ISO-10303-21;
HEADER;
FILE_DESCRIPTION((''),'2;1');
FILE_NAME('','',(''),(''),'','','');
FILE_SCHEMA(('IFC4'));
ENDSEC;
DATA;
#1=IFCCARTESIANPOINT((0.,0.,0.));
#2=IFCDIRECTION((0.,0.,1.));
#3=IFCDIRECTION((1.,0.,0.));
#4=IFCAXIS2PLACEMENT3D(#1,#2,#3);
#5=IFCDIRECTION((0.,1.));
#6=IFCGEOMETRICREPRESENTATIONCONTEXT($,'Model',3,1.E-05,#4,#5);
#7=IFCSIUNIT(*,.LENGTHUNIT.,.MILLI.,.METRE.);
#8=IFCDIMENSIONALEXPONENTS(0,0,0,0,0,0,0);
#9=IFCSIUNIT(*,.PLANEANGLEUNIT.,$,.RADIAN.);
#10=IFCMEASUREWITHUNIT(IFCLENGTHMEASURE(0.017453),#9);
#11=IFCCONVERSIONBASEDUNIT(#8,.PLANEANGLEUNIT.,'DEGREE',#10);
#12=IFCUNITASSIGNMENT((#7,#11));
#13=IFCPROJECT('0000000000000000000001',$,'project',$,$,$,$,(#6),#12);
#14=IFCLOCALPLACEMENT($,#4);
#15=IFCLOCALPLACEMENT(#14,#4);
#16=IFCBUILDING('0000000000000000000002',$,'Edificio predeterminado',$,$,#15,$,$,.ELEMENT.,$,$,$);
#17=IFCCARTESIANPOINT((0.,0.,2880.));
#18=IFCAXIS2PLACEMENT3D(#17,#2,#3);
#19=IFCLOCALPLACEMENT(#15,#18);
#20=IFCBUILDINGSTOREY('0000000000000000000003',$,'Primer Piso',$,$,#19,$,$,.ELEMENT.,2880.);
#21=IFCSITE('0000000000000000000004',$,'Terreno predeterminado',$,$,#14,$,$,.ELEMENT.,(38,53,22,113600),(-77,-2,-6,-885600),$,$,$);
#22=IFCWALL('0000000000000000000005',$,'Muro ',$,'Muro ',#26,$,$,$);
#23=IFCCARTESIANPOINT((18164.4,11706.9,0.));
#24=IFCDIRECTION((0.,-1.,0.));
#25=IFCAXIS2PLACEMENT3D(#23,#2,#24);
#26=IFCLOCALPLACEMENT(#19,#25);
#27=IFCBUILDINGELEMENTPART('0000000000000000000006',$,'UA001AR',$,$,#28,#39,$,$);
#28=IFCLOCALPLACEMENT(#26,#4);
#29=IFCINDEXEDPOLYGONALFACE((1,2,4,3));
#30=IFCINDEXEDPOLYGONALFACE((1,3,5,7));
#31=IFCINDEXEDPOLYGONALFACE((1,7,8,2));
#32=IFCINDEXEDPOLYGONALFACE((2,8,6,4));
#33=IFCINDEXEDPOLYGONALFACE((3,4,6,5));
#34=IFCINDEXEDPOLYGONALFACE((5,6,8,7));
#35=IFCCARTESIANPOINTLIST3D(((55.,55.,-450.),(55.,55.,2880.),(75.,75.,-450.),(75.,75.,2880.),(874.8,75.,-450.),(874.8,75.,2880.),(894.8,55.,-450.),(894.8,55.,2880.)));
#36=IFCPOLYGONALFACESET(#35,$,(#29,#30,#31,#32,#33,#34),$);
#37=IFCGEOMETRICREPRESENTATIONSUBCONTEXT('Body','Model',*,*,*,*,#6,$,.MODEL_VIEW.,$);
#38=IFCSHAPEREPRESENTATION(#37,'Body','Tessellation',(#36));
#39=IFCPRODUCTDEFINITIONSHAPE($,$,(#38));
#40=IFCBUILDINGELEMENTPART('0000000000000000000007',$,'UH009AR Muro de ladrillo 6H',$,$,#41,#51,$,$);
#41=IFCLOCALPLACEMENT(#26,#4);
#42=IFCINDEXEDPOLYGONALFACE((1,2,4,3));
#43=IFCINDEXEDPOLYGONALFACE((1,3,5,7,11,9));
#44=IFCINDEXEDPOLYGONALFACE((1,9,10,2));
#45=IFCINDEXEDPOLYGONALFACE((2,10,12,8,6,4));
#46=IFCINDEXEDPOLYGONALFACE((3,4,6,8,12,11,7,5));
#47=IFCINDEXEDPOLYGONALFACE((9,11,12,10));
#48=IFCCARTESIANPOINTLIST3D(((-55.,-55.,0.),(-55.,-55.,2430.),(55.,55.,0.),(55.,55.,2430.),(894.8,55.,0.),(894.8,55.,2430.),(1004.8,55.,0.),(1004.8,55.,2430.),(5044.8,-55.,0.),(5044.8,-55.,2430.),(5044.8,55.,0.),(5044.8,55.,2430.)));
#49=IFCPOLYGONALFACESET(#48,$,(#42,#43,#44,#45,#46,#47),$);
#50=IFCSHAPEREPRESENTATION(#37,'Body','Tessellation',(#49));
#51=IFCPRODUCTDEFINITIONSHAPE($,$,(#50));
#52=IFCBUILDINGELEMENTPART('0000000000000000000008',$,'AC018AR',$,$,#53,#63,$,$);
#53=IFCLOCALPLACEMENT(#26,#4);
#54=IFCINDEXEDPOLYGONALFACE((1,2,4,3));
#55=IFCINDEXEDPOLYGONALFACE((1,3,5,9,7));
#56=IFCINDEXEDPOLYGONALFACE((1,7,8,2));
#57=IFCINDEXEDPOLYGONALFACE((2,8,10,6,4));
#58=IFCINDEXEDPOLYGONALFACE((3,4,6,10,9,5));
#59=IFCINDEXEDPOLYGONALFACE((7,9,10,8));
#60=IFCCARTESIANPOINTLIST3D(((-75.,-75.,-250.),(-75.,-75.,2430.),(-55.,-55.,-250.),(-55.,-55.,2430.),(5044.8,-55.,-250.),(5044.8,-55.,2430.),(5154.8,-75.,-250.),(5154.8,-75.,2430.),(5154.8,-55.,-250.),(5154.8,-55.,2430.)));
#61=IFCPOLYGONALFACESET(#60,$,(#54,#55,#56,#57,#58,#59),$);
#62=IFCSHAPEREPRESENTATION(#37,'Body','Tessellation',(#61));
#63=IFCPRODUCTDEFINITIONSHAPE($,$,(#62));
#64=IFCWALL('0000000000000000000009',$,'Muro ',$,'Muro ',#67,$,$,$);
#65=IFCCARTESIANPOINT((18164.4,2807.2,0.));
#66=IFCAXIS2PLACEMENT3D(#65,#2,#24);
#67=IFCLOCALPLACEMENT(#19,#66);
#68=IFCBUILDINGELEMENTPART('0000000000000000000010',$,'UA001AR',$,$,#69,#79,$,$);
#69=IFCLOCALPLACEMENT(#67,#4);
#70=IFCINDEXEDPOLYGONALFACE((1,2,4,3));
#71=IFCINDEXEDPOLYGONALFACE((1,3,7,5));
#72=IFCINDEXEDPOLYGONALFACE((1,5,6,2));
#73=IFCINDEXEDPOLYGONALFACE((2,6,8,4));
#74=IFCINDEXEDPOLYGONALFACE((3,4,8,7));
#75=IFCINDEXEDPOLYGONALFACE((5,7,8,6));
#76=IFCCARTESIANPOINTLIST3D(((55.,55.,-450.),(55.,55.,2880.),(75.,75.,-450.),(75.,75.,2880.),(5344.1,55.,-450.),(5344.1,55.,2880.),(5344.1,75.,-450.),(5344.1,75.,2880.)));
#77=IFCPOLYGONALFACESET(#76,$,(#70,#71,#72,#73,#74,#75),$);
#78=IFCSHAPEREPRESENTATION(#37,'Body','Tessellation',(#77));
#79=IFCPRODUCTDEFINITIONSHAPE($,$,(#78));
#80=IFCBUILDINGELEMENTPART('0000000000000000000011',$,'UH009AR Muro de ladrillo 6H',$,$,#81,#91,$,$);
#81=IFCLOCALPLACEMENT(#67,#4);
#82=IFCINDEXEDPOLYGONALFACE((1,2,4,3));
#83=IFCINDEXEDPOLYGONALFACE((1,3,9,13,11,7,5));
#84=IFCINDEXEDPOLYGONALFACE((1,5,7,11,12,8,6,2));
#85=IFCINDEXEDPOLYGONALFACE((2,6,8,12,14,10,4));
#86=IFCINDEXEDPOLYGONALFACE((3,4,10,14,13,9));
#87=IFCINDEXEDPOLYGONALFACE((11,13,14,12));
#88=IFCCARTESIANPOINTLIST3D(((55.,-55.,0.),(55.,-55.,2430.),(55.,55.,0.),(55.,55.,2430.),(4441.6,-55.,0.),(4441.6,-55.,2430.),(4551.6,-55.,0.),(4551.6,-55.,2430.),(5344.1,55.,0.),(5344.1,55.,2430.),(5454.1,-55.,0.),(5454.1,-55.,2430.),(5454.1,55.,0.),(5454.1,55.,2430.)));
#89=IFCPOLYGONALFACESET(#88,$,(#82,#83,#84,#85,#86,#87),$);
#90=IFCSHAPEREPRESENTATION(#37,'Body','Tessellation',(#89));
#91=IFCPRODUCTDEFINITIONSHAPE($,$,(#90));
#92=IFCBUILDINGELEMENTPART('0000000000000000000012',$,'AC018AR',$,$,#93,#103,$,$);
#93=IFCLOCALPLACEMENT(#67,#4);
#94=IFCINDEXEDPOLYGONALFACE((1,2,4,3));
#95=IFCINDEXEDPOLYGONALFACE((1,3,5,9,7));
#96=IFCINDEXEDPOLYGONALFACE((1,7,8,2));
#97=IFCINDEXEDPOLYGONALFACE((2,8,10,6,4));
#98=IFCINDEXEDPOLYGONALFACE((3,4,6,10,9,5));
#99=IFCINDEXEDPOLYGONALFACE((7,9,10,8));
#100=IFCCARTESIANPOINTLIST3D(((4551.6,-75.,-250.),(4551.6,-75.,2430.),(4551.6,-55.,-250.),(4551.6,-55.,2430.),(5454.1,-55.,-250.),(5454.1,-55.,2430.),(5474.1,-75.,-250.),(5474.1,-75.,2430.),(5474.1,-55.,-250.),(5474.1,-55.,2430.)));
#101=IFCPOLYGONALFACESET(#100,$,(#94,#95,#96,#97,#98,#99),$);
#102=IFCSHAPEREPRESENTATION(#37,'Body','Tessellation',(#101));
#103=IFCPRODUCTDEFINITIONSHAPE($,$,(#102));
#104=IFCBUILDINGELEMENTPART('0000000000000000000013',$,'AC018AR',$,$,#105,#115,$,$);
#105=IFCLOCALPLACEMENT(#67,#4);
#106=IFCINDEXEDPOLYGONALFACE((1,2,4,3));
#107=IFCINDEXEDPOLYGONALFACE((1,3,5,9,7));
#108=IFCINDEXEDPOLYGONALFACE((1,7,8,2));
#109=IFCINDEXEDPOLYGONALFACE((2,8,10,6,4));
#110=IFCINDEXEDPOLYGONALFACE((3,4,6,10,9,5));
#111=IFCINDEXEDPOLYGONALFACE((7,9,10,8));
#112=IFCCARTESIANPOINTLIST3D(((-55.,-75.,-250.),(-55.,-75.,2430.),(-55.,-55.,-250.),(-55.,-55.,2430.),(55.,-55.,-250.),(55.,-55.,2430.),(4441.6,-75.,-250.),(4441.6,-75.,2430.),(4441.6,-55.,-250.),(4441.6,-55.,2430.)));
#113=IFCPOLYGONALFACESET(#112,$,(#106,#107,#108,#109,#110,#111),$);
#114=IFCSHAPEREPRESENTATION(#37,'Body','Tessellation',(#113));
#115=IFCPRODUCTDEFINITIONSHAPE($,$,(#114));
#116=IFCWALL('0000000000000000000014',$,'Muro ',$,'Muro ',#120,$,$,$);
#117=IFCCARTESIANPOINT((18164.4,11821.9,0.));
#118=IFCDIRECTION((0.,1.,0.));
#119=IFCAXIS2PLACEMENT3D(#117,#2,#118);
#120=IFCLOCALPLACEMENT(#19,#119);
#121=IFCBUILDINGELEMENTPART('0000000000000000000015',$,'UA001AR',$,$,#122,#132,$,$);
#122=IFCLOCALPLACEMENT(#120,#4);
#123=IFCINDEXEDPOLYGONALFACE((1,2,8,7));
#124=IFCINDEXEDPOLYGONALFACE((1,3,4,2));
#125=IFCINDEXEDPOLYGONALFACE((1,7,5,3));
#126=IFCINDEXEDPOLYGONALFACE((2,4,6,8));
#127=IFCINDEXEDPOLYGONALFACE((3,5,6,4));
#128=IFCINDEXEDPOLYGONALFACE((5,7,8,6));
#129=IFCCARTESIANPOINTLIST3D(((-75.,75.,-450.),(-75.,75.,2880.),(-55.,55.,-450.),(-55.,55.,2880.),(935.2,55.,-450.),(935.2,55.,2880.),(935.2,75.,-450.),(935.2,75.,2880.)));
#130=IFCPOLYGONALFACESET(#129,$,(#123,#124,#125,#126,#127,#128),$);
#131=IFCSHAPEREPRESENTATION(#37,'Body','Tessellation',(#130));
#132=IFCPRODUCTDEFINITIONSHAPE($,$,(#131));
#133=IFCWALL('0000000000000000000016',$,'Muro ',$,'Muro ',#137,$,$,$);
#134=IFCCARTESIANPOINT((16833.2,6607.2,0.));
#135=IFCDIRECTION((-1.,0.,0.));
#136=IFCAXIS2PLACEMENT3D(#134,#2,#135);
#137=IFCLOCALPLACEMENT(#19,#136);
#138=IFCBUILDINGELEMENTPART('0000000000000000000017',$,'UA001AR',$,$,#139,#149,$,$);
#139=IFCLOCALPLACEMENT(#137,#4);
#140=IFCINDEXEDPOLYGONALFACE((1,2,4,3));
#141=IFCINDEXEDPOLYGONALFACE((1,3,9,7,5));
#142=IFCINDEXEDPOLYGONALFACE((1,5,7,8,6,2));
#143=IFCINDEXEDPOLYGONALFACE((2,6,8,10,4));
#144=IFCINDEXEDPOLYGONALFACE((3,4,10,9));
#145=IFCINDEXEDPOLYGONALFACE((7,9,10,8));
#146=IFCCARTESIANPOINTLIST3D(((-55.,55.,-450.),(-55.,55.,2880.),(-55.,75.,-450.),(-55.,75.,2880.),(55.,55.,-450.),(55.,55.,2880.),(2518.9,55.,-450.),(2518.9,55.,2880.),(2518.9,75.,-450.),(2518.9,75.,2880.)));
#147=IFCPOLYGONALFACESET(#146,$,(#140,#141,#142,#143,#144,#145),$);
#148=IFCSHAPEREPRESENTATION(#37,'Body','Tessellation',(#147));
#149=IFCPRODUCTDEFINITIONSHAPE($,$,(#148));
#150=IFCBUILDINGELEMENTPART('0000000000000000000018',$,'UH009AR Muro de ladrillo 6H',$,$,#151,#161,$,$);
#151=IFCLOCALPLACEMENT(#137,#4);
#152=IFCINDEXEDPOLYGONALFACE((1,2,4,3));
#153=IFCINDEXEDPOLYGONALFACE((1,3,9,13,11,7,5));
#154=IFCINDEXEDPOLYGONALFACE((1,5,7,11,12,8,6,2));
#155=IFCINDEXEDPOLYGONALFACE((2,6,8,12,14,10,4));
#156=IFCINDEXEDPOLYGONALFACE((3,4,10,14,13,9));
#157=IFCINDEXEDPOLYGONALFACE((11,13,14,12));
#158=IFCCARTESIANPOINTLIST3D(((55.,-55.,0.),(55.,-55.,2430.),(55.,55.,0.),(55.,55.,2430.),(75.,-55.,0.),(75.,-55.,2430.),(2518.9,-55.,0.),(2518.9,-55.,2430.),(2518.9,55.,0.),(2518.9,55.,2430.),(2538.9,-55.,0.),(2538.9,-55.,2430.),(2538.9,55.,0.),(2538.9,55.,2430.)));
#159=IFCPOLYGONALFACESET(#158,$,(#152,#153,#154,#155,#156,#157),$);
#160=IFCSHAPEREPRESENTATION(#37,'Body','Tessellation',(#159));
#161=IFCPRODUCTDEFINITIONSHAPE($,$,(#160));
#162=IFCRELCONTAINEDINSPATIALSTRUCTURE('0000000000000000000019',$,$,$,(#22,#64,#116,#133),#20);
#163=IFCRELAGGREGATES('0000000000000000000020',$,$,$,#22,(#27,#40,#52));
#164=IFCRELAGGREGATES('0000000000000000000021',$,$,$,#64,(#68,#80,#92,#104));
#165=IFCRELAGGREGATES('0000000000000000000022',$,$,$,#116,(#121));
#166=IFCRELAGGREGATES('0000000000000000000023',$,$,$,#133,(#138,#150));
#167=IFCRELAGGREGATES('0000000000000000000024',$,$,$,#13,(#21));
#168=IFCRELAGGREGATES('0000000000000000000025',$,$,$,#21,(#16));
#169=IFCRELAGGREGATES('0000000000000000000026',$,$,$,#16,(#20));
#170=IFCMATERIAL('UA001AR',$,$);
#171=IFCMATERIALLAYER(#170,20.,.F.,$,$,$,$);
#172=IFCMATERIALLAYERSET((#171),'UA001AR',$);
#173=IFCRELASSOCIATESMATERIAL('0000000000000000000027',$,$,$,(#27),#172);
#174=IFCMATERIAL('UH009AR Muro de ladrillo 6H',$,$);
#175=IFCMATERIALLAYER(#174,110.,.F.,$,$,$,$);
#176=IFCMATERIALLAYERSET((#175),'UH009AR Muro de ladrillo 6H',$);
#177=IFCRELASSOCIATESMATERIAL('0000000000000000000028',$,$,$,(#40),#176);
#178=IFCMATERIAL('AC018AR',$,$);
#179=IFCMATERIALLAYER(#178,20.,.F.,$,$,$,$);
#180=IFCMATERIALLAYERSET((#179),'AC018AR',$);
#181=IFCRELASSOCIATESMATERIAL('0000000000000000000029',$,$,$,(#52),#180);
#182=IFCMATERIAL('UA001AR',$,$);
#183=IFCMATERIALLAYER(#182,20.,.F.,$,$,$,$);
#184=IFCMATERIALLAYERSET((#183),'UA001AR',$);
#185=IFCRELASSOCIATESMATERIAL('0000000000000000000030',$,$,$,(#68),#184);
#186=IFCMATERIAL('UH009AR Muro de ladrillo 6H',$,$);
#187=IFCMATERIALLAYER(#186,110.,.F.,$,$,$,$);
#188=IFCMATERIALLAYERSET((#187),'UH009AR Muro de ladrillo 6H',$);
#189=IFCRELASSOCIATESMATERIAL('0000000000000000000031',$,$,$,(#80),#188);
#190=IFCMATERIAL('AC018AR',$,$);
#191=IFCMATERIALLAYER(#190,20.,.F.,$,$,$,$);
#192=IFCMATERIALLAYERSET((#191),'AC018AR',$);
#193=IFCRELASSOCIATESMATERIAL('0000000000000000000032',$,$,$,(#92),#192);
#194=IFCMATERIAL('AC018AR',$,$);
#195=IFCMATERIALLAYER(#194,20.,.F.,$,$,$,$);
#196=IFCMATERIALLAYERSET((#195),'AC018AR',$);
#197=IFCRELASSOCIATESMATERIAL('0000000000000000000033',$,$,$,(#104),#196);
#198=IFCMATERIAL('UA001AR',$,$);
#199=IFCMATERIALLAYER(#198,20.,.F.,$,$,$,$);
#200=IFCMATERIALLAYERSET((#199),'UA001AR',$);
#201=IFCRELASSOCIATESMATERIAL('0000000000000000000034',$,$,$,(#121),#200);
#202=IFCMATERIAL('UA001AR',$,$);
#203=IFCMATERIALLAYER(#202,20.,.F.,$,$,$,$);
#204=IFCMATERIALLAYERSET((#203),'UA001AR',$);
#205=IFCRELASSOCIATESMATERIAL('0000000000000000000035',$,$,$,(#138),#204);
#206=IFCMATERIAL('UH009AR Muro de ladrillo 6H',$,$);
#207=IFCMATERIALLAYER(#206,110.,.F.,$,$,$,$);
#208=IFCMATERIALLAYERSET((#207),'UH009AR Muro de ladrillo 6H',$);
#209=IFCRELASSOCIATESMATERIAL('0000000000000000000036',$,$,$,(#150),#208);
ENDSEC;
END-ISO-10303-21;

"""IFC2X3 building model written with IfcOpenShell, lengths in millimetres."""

from ifc_helpers import new_model, entity, si_unit, converted_unit, direction, frame, origin_with_axes, place, context, subcontext, project, spatial, polyline, outline, extrude, material, layer, layer_set, layer_usage, element, aggregate, save


model = new_model("IFC2X3")

# Units and contexts
model_context = context("Model", 3, precision=1e-05, world=origin_with_axes(), true_north=direction((0.0, 1.0)))
body_context = subcontext(model_context, "Body", "Model", "MODEL_VIEW")
ifc_project = project(units=[si_unit("LENGTHUNIT", "METRE", prefix="MILLI"), converted_unit("PLANEANGLEUNIT", "DEGREE", entity("IfcLengthMeasure", 0.017453), si_unit("PLANEANGLEUNIT", "RADIAN"), dimensions=[0, 0, 0, 0, 0, 0, 0])], contexts=[model_context])

# Site, building, storey
site_placement = place(None, origin_with_axes())
site = spatial("IfcSite", under=ifc_project, at=site_placement, Name="Terreno predeterminado", CompositionType="ELEMENT", RefLatitude=(38, 53, 22, 113600), RefLongitude=(-77, -2, -6, -885600))
building_placement = place(site_placement, origin_with_axes())
building = spatial("IfcBuilding", under=site, at=building_placement, Name="Edificio predeterminado", CompositionType="ELEMENT")
storey_placement = place(building_placement, frame((0.0, 0.0, 2880.0), z_axis=(0.0, 0.0, 1.0), x_axis=(1.0, 0.0, 0.0)))
storey = spatial("IfcBuildingStorey", under=building, at=storey_placement, Name="Primer Piso", CompositionType="ELEMENT", Elevation=2880.0)

# Walls, building element parts
wall_1_placement = place(storey_placement, frame((18164.4, 11706.9, 0.0), z_axis=(0.0, 0.0, 1.0), x_axis=(0.0, -1.0, 0.0)))
wall_1 = element("IfcWall", 1, at=wall_1_placement, inside=storey, Name="Muro ", ObjectType="Muro ")
ifc_material_1 = material(Name="UA001AR")
ifc_layer_1 = layer(ifc_material_1, 20.0, ventilated=False)
ifc_layer_set_1 = layer_set([ifc_layer_1], Name="UA001AR")
ifc_layer_usage_1 = layer_usage(ifc_layer_set_1, "AXIS2", "NEGATIVE", -75.0)
building_element_part_1_placement = place(wall_1_placement, origin_with_axes())
building_element_part_1 = element("IfcBuildingElementPart", 2, at=building_element_part_1_placement, material=ifc_layer_usage_1, Name="UA001AR", context=body_context, shape_type="SweptSolid", body=[
    extrude(outline(polyline([(874.8, 75.0), (894.8, 55.0), (55.0, 55.0), (75.0, 75.0), (874.8, 75.0)])), frame((0.0, 0.0, -450.0), z_axis=(0.0, 0.0, 1.0), x_axis=(1.0, 0.0, 0.0)), (0.0, 0.0, 1.0), 3330.0),
])
ifc_material_2 = material(Name="UH009AR Muro de ladrillo 6H")
ifc_layer_2 = layer(ifc_material_2, 110.0, ventilated=False)
ifc_layer_set_2 = layer_set([ifc_layer_2], Name="UH009AR Muro de ladrillo 6H")
ifc_layer_usage_2 = layer_usage(ifc_layer_set_2, "AXIS2", "NEGATIVE", -55.0)
building_element_part_2_placement = place(wall_1_placement, origin_with_axes())
building_element_part_2 = element("IfcBuildingElementPart", 3, at=building_element_part_2_placement, material=ifc_layer_usage_2, Name="UH009AR Muro de ladrillo 6H", context=body_context, shape_type="SweptSolid", body=[
    extrude(outline(polyline([(5044.8, 55.0), (5044.8, -55.0), (-55.0, -55.0), (55.0, 55.0), (894.8, 55.0), (1004.8, 55.0), (5044.8, 55.0)])), origin_with_axes(), (0.0, 0.0, 1.0), 2430.0),
])
ifc_material_3 = material(Name="AC018AR")
ifc_layer_3 = layer(ifc_material_3, 20.0, ventilated=False)
ifc_layer_set_3 = layer_set([ifc_layer_3], Name="AC018AR")
ifc_layer_usage_3 = layer_usage(ifc_layer_set_3, "AXIS2", "NEGATIVE", 55.0)
building_element_part_3_placement = place(wall_1_placement, origin_with_axes())
building_element_part_3 = element("IfcBuildingElementPart", 4, at=building_element_part_3_placement, material=ifc_layer_usage_3, Name="AC018AR", context=body_context, shape_type="SweptSolid", body=[
    extrude(outline(polyline([(5154.8, -55.0), (5154.8, -75.0), (-75.0, -75.0), (-55.0, -55.0), (5044.8, -55.0), (5154.8, -55.0)])), frame((0.0, 0.0, -250.0), z_axis=(0.0, 0.0, 1.0), x_axis=(1.0, 0.0, 0.0)), (0.0, 0.0, 1.0), 2680.0),
])
aggregate(wall_1, [building_element_part_1, building_element_part_2, building_element_part_3])
wall_2_placement = place(storey_placement, frame((18164.4, 2807.2, 0.0), z_axis=(0.0, 0.0, 1.0), x_axis=(0.0, -1.0, 0.0)))
wall_2 = element("IfcWall", 5, at=wall_2_placement, inside=storey, Name="Muro ", ObjectType="Muro ")
ifc_material_4 = material(Name="UA001AR")
ifc_layer_4 = layer(ifc_material_4, 20.0, ventilated=False)
ifc_layer_set_4 = layer_set([ifc_layer_4], Name="UA001AR")
ifc_layer_usage_4 = layer_usage(ifc_layer_set_4, "AXIS2", "NEGATIVE", -75.0)
building_element_part_4_placement = place(wall_2_placement, origin_with_axes())
building_element_part_4 = element("IfcBuildingElementPart", 6, at=building_element_part_4_placement, material=ifc_layer_usage_4, Name="UA001AR", context=body_context, shape_type="SweptSolid", body=[
    extrude(outline(polyline([(5344.1, 75.0), (5344.1, 55.0), (55.0, 55.0), (75.0, 75.0), (5344.1, 75.0)])), frame((0.0, 0.0, -450.0), z_axis=(0.0, 0.0, 1.0), x_axis=(1.0, 0.0, 0.0)), (0.0, 0.0, 1.0), 3330.0),
])
ifc_material_5 = material(Name="UH009AR Muro de ladrillo 6H")
ifc_layer_5 = layer(ifc_material_5, 110.0, ventilated=False)
ifc_layer_set_5 = layer_set([ifc_layer_5], Name="UH009AR Muro de ladrillo 6H")
ifc_layer_usage_5 = layer_usage(ifc_layer_set_5, "AXIS2", "NEGATIVE", -55.0)
building_element_part_5_placement = place(wall_2_placement, origin_with_axes())
building_element_part_5 = element("IfcBuildingElementPart", 7, at=building_element_part_5_placement, material=ifc_layer_usage_5, Name="UH009AR Muro de ladrillo 6H", context=body_context, shape_type="SweptSolid", body=[
    extrude(outline(polyline([(5454.1, 55.0), (5454.1, -55.0), (4551.6, -55.0), (4441.6, -55.0), (55.0, -55.0), (55.0, 55.0), (5344.1, 55.0), (5454.1, 55.0)])), origin_with_axes(), (0.0, 0.0, 1.0), 2430.0),
])
ifc_material_6 = material(Name="AC018AR")
ifc_layer_6 = layer(ifc_material_6, 20.0, ventilated=False)
ifc_layer_set_6 = layer_set([ifc_layer_6], Name="AC018AR")
ifc_layer_usage_6 = layer_usage(ifc_layer_set_6, "AXIS2", "NEGATIVE", 55.0)
building_element_part_6_placement = place(wall_2_placement, origin_with_axes())
building_element_part_6 = element("IfcBuildingElementPart", 8, at=building_element_part_6_placement, material=ifc_layer_usage_6, Name="AC018AR", context=body_context, shape_type="SweptSolid", body=[
    extrude(outline(polyline([(5474.1, -55.0), (5474.1, -75.0), (4551.6, -75.0), (4551.6, -55.0), (5454.1, -55.0), (5474.1, -55.0)])), frame((0.0, 0.0, -250.0), z_axis=(0.0, 0.0, 1.0), x_axis=(1.0, 0.0, 0.0)), (0.0, 0.0, 1.0), 2680.0),
])
ifc_material_7 = material(Name="AC018AR")
ifc_layer_7 = layer(ifc_material_7, 20.0, ventilated=False)
ifc_layer_set_7 = layer_set([ifc_layer_7], Name="AC018AR")
ifc_layer_usage_7 = layer_usage(ifc_layer_set_7, "AXIS2", "NEGATIVE", 55.0)
building_element_part_7_placement = place(wall_2_placement, origin_with_axes())
building_element_part_7 = element("IfcBuildingElementPart", 9, at=building_element_part_7_placement, material=ifc_layer_usage_7, Name="AC018AR", context=body_context, shape_type="SweptSolid", body=[
    extrude(outline(polyline([(4441.6, -55.0), (4441.6, -75.0), (-55.0, -75.0), (-55.0, -55.0), (55.0, -55.0), (4441.6, -55.0)])), frame((0.0, 0.0, -250.0), z_axis=(0.0, 0.0, 1.0), x_axis=(1.0, 0.0, 0.0)), (0.0, 0.0, 1.0), 2680.0),
])
aggregate(wall_2, [building_element_part_4, building_element_part_5, building_element_part_6, building_element_part_7])

# Wall, building element part
wall_3_placement = place(storey_placement, frame((18164.4, 11821.9, 0.0), z_axis=(0.0, 0.0, 1.0), x_axis=(0.0, 1.0, 0.0)))
wall_3 = element("IfcWall", 10, at=wall_3_placement, inside=storey, Name="Muro ", ObjectType="Muro ")
ifc_material_8 = material(Name="UA001AR")
ifc_layer_8 = layer(ifc_material_8, 20.0, ventilated=False)
ifc_layer_set_8 = layer_set([ifc_layer_8], Name="UA001AR")
ifc_layer_usage_8 = layer_usage(ifc_layer_set_8, "AXIS2", "NEGATIVE", -75.0)
building_element_part_8_placement = place(wall_3_placement, origin_with_axes())
building_element_part_8 = element("IfcBuildingElementPart", 11, at=building_element_part_8_placement, material=ifc_layer_usage_8, Name="UA001AR", context=body_context, shape_type="SweptSolid", body=[
    extrude(outline(polyline([(935.2, 75.0), (935.2, 55.0), (-55.0, 55.0), (-75.0, 75.0), (935.2, 75.0)])), frame((0.0, 0.0, -450.0), z_axis=(0.0, 0.0, 1.0), x_axis=(1.0, 0.0, 0.0)), (0.0, 0.0, 1.0), 3330.0),
])
aggregate(wall_3, [building_element_part_8])

# Wall, building element parts
wall_4_placement = place(storey_placement, frame((16833.2, 6607.2, 0.0), z_axis=(0.0, 0.0, 1.0), x_axis=(-1.0, 0.0, 0.0)))
wall_4 = element("IfcWall", 12, at=wall_4_placement, inside=storey, Name="Muro ", ObjectType="Muro ")
ifc_material_9 = material(Name="UA001AR")
ifc_layer_9 = layer(ifc_material_9, 20.0, ventilated=False)
ifc_layer_set_9 = layer_set([ifc_layer_9], Name="UA001AR")
ifc_layer_usage_9 = layer_usage(ifc_layer_set_9, "AXIS2", "NEGATIVE", -75.0)
building_element_part_9_placement = place(wall_4_placement, origin_with_axes())
building_element_part_9 = element("IfcBuildingElementPart", 13, at=building_element_part_9_placement, material=ifc_layer_usage_9, Name="UA001AR", context=body_context, shape_type="SweptSolid", body=[
    extrude(outline(polyline([(2518.9, 75.0), (2518.9, 55.0), (55.0, 55.0), (-55.0, 55.0), (-55.0, 75.0), (2518.9, 75.0)])), frame((0.0, 0.0, -450.0), z_axis=(0.0, 0.0, 1.0), x_axis=(1.0, 0.0, 0.0)), (0.0, 0.0, 1.0), 3330.0),
])
ifc_material_10 = material(Name="UH009AR Muro de ladrillo 6H")
ifc_layer_10 = layer(ifc_material_10, 110.0, ventilated=False)
ifc_layer_set_10 = layer_set([ifc_layer_10], Name="UH009AR Muro de ladrillo 6H")
ifc_layer_usage_10 = layer_usage(ifc_layer_set_10, "AXIS2", "NEGATIVE", -55.0)
building_element_part_10_placement = place(wall_4_placement, origin_with_axes())
building_element_part_10 = element("IfcBuildingElementPart", 14, at=building_element_part_10_placement, material=ifc_layer_usage_10, Name="UH009AR Muro de ladrillo 6H", context=body_context, shape_type="SweptSolid", body=[
    extrude(outline(polyline([(2538.9, 55.0), (2538.9, -55.0), (2518.9, -55.0), (75.0, -55.0), (55.0, -55.0), (55.0, 55.0), (2518.9, 55.0), (2538.9, 55.0)])), origin_with_axes(), (0.0, 0.0, 1.0), 2430.0),
])
aggregate(wall_4, [building_element_part_9, building_element_part_10])

save(model, "model.ifc")
